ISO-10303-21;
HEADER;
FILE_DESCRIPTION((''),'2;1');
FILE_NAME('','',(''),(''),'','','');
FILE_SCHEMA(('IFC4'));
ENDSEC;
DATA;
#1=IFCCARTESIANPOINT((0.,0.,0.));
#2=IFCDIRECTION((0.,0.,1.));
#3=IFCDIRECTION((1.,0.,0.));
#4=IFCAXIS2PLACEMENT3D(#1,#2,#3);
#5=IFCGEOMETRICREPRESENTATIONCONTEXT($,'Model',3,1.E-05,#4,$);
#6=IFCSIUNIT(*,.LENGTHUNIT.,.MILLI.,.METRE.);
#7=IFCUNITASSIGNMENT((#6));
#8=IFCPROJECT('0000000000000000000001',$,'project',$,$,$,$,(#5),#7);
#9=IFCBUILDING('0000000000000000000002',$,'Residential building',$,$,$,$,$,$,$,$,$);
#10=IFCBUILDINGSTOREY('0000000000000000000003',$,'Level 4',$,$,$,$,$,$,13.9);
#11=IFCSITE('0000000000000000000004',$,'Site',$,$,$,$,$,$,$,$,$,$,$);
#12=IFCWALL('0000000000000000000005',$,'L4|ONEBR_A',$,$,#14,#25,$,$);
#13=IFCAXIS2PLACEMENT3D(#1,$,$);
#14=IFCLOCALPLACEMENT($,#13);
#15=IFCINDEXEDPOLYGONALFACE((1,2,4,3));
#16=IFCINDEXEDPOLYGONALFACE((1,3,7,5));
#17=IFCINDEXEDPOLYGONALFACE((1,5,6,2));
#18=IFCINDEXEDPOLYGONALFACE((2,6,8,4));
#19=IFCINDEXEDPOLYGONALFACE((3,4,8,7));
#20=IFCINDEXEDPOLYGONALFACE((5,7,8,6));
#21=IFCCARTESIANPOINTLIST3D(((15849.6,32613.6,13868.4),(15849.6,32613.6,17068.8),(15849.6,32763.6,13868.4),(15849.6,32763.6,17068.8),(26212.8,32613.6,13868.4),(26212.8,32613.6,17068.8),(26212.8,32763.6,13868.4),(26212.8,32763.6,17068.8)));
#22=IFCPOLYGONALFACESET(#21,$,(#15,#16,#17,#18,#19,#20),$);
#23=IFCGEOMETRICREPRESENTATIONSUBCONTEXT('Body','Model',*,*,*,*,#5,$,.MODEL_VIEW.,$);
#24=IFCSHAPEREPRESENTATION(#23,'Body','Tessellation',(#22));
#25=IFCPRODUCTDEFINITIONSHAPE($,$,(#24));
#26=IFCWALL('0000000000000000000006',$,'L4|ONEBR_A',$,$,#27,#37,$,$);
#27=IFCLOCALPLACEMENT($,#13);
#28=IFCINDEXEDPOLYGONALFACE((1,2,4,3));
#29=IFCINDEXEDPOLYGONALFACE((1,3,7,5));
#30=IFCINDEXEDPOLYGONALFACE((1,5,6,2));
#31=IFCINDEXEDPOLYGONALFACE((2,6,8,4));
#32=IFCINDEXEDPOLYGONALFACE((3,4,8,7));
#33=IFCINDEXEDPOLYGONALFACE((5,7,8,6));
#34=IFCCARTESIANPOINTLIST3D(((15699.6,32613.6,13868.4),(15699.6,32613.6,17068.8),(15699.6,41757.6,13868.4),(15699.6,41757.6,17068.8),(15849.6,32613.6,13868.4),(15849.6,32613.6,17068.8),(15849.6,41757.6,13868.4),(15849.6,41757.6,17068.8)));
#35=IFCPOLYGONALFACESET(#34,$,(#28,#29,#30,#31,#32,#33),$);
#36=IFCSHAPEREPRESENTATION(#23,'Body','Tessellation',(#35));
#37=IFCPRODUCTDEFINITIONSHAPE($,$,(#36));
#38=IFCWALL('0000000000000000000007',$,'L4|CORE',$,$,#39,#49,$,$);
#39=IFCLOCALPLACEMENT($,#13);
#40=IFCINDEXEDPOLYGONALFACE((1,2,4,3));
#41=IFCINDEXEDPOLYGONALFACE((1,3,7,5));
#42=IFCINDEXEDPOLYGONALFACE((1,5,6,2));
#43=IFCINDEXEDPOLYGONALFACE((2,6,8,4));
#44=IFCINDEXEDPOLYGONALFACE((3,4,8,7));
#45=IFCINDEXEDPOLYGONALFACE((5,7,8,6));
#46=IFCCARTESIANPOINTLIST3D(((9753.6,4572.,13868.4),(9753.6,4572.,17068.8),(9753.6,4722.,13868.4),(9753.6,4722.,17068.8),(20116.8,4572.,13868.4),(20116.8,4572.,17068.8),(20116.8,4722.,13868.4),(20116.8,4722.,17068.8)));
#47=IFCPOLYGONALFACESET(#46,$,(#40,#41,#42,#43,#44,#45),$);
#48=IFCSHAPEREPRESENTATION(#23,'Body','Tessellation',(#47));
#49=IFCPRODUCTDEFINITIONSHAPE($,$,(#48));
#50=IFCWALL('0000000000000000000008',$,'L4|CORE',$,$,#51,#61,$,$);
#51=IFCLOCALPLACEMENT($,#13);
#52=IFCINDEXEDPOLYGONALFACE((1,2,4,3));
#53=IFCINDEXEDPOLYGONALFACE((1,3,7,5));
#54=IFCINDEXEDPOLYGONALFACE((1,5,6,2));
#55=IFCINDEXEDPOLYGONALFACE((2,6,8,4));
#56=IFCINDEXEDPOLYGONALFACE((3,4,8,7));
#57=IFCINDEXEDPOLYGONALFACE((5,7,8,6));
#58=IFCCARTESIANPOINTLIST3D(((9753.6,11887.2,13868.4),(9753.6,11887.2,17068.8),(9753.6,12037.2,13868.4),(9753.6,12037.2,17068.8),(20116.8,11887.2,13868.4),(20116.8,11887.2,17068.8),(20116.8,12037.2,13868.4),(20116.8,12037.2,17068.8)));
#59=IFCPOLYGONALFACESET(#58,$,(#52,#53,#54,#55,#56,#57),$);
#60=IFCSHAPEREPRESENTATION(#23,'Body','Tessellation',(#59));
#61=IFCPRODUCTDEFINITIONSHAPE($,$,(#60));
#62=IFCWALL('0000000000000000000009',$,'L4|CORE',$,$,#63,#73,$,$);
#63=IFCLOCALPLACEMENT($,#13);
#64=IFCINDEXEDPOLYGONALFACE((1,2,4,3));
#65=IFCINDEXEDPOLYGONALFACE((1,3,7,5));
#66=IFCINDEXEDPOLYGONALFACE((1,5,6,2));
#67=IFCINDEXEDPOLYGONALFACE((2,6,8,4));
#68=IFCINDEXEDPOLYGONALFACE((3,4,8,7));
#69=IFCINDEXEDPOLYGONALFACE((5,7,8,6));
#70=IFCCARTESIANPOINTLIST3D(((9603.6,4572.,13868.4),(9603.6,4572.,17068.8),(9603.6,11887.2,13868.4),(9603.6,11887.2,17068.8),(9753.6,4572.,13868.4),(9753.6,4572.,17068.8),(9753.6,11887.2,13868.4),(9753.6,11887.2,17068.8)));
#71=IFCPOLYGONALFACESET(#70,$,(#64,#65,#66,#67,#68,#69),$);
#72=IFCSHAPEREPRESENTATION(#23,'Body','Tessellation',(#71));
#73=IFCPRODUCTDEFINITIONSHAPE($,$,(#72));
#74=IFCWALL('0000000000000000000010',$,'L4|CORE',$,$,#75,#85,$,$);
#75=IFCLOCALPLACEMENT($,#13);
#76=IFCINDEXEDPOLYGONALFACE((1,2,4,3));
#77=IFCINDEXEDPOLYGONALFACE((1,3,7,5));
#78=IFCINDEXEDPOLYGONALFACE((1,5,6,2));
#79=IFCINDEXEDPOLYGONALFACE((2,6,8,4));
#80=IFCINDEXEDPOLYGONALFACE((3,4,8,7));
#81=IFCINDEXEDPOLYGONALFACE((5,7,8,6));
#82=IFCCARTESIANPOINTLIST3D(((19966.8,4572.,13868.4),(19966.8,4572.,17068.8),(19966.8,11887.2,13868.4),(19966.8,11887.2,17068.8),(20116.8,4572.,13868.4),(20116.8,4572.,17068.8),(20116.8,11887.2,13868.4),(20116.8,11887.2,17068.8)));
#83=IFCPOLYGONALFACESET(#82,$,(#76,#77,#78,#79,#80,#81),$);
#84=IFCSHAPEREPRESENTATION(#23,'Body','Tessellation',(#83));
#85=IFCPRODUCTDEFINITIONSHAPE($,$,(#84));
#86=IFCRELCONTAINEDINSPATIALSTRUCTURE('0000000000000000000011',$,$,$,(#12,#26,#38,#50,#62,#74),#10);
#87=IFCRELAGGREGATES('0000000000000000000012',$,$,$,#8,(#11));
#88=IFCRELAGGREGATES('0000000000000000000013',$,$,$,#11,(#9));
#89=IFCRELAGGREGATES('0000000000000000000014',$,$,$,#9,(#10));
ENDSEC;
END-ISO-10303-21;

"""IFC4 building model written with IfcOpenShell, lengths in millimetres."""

from ifc_helpers import new_model, si_unit, frame, origin_with_axes, place, context, subcontext, project, spatial, indexed_curve, outline, extrude, element, save


model = new_model("IFC4")

# Units and contexts
model_context = context("Model", 3, precision=1e-05, world=origin_with_axes())
body_context = subcontext(model_context, "Body", "Model", "MODEL_VIEW")
ifc_project = project(units=[si_unit("LENGTHUNIT", "METRE", prefix="MILLI")], contexts=[model_context])

# Site, building, storey
site = spatial("IfcSite", under=ifc_project, Name="Site")
building = spatial("IfcBuilding", under=site, Name="Residential building")
storey = spatial("IfcBuildingStorey", under=building, Name="Level 4", Elevation=13.9)

# Walls
for number, where, z_axis, x_axis, name in (
    (1, (15849.6, 32613.6, 13868.4), (0.0, 0.0, 1.0), (1.0, 0.0, 0.0), "L4|ONEBR_A"),
):
    element("IfcWall", number, at=place(None, frame(where, z_axis=z_axis, x_axis=x_axis)), inside=storey, Name=name, context=body_context, shape_type="SweptSolid", body=[
        extrude(outline(indexed_curve([(0.0, 0.0), (0.0, 150.0), (10363.2, 150.0), (10363.2, 0.0), (0.0, 0.0)], self_intersect=False)), origin_with_axes(), (0.0, 0.0, 1.0), 3200.4),
    ])
wall_1_placement = place(None, frame((15849.6, 32613.6, 13868.4), z_axis=(0.0, 0.0, 1.0), x_axis=(0.0, 1.0, 0.0)))
element("IfcWall", 2, at=wall_1_placement, inside=storey, Name="L4|ONEBR_A", context=body_context, shape_type="SweptSolid", body=[
    extrude(outline(indexed_curve([(0.0, 0.0), (0.0, 150.0), (9144.0, 150.0), (9144.0, 0.0), (0.0, 0.0)], self_intersect=False)), origin_with_axes(), (0.0, 0.0, 1.0), 3200.4),
])
for number, where, z_axis, x_axis, name in (
    (3, (9753.6, 4572.0, 13868.4), (0.0, 0.0, 1.0), (1.0, 0.0, 0.0), "L4|CORE"),
    (4, (9753.6, 11887.2, 13868.4), (0.0, 0.0, 1.0), (1.0, 0.0, 0.0), "L4|CORE"),
):
    element("IfcWall", number, at=place(None, frame(where, z_axis=z_axis, x_axis=x_axis)), inside=storey, Name=name, context=body_context, shape_type="SweptSolid", body=[
        extrude(outline(indexed_curve([(0.0, 0.0), (0.0, 150.0), (10363.2, 150.0), (10363.2, 0.0), (0.0, 0.0)], self_intersect=False)), origin_with_axes(), (0.0, 0.0, 1.0), 3200.4),
    ])
for number, where, z_axis, x_axis, name in (
    (5, (9753.6, 4572.0, 13868.4), (0.0, 0.0, 1.0), (0.0, 1.0, 0.0), "L4|CORE"),
    (6, (20116.8, 4572.0, 13868.4), (0.0, 0.0, 1.0), (0.0, 1.0, 0.0), "L4|CORE"),
):
    element("IfcWall", number, at=place(None, frame(where, z_axis=z_axis, x_axis=x_axis)), inside=storey, Name=name, context=body_context, shape_type="SweptSolid", body=[
        extrude(outline(indexed_curve([(0.0, 0.0), (0.0, 150.0), (7315.2, 150.0), (7315.2, 0.0), (0.0, 0.0)], self_intersect=False)), origin_with_axes(), (0.0, 0.0, 1.0), 3200.4),
    ])

save(model, "model.ifc")
